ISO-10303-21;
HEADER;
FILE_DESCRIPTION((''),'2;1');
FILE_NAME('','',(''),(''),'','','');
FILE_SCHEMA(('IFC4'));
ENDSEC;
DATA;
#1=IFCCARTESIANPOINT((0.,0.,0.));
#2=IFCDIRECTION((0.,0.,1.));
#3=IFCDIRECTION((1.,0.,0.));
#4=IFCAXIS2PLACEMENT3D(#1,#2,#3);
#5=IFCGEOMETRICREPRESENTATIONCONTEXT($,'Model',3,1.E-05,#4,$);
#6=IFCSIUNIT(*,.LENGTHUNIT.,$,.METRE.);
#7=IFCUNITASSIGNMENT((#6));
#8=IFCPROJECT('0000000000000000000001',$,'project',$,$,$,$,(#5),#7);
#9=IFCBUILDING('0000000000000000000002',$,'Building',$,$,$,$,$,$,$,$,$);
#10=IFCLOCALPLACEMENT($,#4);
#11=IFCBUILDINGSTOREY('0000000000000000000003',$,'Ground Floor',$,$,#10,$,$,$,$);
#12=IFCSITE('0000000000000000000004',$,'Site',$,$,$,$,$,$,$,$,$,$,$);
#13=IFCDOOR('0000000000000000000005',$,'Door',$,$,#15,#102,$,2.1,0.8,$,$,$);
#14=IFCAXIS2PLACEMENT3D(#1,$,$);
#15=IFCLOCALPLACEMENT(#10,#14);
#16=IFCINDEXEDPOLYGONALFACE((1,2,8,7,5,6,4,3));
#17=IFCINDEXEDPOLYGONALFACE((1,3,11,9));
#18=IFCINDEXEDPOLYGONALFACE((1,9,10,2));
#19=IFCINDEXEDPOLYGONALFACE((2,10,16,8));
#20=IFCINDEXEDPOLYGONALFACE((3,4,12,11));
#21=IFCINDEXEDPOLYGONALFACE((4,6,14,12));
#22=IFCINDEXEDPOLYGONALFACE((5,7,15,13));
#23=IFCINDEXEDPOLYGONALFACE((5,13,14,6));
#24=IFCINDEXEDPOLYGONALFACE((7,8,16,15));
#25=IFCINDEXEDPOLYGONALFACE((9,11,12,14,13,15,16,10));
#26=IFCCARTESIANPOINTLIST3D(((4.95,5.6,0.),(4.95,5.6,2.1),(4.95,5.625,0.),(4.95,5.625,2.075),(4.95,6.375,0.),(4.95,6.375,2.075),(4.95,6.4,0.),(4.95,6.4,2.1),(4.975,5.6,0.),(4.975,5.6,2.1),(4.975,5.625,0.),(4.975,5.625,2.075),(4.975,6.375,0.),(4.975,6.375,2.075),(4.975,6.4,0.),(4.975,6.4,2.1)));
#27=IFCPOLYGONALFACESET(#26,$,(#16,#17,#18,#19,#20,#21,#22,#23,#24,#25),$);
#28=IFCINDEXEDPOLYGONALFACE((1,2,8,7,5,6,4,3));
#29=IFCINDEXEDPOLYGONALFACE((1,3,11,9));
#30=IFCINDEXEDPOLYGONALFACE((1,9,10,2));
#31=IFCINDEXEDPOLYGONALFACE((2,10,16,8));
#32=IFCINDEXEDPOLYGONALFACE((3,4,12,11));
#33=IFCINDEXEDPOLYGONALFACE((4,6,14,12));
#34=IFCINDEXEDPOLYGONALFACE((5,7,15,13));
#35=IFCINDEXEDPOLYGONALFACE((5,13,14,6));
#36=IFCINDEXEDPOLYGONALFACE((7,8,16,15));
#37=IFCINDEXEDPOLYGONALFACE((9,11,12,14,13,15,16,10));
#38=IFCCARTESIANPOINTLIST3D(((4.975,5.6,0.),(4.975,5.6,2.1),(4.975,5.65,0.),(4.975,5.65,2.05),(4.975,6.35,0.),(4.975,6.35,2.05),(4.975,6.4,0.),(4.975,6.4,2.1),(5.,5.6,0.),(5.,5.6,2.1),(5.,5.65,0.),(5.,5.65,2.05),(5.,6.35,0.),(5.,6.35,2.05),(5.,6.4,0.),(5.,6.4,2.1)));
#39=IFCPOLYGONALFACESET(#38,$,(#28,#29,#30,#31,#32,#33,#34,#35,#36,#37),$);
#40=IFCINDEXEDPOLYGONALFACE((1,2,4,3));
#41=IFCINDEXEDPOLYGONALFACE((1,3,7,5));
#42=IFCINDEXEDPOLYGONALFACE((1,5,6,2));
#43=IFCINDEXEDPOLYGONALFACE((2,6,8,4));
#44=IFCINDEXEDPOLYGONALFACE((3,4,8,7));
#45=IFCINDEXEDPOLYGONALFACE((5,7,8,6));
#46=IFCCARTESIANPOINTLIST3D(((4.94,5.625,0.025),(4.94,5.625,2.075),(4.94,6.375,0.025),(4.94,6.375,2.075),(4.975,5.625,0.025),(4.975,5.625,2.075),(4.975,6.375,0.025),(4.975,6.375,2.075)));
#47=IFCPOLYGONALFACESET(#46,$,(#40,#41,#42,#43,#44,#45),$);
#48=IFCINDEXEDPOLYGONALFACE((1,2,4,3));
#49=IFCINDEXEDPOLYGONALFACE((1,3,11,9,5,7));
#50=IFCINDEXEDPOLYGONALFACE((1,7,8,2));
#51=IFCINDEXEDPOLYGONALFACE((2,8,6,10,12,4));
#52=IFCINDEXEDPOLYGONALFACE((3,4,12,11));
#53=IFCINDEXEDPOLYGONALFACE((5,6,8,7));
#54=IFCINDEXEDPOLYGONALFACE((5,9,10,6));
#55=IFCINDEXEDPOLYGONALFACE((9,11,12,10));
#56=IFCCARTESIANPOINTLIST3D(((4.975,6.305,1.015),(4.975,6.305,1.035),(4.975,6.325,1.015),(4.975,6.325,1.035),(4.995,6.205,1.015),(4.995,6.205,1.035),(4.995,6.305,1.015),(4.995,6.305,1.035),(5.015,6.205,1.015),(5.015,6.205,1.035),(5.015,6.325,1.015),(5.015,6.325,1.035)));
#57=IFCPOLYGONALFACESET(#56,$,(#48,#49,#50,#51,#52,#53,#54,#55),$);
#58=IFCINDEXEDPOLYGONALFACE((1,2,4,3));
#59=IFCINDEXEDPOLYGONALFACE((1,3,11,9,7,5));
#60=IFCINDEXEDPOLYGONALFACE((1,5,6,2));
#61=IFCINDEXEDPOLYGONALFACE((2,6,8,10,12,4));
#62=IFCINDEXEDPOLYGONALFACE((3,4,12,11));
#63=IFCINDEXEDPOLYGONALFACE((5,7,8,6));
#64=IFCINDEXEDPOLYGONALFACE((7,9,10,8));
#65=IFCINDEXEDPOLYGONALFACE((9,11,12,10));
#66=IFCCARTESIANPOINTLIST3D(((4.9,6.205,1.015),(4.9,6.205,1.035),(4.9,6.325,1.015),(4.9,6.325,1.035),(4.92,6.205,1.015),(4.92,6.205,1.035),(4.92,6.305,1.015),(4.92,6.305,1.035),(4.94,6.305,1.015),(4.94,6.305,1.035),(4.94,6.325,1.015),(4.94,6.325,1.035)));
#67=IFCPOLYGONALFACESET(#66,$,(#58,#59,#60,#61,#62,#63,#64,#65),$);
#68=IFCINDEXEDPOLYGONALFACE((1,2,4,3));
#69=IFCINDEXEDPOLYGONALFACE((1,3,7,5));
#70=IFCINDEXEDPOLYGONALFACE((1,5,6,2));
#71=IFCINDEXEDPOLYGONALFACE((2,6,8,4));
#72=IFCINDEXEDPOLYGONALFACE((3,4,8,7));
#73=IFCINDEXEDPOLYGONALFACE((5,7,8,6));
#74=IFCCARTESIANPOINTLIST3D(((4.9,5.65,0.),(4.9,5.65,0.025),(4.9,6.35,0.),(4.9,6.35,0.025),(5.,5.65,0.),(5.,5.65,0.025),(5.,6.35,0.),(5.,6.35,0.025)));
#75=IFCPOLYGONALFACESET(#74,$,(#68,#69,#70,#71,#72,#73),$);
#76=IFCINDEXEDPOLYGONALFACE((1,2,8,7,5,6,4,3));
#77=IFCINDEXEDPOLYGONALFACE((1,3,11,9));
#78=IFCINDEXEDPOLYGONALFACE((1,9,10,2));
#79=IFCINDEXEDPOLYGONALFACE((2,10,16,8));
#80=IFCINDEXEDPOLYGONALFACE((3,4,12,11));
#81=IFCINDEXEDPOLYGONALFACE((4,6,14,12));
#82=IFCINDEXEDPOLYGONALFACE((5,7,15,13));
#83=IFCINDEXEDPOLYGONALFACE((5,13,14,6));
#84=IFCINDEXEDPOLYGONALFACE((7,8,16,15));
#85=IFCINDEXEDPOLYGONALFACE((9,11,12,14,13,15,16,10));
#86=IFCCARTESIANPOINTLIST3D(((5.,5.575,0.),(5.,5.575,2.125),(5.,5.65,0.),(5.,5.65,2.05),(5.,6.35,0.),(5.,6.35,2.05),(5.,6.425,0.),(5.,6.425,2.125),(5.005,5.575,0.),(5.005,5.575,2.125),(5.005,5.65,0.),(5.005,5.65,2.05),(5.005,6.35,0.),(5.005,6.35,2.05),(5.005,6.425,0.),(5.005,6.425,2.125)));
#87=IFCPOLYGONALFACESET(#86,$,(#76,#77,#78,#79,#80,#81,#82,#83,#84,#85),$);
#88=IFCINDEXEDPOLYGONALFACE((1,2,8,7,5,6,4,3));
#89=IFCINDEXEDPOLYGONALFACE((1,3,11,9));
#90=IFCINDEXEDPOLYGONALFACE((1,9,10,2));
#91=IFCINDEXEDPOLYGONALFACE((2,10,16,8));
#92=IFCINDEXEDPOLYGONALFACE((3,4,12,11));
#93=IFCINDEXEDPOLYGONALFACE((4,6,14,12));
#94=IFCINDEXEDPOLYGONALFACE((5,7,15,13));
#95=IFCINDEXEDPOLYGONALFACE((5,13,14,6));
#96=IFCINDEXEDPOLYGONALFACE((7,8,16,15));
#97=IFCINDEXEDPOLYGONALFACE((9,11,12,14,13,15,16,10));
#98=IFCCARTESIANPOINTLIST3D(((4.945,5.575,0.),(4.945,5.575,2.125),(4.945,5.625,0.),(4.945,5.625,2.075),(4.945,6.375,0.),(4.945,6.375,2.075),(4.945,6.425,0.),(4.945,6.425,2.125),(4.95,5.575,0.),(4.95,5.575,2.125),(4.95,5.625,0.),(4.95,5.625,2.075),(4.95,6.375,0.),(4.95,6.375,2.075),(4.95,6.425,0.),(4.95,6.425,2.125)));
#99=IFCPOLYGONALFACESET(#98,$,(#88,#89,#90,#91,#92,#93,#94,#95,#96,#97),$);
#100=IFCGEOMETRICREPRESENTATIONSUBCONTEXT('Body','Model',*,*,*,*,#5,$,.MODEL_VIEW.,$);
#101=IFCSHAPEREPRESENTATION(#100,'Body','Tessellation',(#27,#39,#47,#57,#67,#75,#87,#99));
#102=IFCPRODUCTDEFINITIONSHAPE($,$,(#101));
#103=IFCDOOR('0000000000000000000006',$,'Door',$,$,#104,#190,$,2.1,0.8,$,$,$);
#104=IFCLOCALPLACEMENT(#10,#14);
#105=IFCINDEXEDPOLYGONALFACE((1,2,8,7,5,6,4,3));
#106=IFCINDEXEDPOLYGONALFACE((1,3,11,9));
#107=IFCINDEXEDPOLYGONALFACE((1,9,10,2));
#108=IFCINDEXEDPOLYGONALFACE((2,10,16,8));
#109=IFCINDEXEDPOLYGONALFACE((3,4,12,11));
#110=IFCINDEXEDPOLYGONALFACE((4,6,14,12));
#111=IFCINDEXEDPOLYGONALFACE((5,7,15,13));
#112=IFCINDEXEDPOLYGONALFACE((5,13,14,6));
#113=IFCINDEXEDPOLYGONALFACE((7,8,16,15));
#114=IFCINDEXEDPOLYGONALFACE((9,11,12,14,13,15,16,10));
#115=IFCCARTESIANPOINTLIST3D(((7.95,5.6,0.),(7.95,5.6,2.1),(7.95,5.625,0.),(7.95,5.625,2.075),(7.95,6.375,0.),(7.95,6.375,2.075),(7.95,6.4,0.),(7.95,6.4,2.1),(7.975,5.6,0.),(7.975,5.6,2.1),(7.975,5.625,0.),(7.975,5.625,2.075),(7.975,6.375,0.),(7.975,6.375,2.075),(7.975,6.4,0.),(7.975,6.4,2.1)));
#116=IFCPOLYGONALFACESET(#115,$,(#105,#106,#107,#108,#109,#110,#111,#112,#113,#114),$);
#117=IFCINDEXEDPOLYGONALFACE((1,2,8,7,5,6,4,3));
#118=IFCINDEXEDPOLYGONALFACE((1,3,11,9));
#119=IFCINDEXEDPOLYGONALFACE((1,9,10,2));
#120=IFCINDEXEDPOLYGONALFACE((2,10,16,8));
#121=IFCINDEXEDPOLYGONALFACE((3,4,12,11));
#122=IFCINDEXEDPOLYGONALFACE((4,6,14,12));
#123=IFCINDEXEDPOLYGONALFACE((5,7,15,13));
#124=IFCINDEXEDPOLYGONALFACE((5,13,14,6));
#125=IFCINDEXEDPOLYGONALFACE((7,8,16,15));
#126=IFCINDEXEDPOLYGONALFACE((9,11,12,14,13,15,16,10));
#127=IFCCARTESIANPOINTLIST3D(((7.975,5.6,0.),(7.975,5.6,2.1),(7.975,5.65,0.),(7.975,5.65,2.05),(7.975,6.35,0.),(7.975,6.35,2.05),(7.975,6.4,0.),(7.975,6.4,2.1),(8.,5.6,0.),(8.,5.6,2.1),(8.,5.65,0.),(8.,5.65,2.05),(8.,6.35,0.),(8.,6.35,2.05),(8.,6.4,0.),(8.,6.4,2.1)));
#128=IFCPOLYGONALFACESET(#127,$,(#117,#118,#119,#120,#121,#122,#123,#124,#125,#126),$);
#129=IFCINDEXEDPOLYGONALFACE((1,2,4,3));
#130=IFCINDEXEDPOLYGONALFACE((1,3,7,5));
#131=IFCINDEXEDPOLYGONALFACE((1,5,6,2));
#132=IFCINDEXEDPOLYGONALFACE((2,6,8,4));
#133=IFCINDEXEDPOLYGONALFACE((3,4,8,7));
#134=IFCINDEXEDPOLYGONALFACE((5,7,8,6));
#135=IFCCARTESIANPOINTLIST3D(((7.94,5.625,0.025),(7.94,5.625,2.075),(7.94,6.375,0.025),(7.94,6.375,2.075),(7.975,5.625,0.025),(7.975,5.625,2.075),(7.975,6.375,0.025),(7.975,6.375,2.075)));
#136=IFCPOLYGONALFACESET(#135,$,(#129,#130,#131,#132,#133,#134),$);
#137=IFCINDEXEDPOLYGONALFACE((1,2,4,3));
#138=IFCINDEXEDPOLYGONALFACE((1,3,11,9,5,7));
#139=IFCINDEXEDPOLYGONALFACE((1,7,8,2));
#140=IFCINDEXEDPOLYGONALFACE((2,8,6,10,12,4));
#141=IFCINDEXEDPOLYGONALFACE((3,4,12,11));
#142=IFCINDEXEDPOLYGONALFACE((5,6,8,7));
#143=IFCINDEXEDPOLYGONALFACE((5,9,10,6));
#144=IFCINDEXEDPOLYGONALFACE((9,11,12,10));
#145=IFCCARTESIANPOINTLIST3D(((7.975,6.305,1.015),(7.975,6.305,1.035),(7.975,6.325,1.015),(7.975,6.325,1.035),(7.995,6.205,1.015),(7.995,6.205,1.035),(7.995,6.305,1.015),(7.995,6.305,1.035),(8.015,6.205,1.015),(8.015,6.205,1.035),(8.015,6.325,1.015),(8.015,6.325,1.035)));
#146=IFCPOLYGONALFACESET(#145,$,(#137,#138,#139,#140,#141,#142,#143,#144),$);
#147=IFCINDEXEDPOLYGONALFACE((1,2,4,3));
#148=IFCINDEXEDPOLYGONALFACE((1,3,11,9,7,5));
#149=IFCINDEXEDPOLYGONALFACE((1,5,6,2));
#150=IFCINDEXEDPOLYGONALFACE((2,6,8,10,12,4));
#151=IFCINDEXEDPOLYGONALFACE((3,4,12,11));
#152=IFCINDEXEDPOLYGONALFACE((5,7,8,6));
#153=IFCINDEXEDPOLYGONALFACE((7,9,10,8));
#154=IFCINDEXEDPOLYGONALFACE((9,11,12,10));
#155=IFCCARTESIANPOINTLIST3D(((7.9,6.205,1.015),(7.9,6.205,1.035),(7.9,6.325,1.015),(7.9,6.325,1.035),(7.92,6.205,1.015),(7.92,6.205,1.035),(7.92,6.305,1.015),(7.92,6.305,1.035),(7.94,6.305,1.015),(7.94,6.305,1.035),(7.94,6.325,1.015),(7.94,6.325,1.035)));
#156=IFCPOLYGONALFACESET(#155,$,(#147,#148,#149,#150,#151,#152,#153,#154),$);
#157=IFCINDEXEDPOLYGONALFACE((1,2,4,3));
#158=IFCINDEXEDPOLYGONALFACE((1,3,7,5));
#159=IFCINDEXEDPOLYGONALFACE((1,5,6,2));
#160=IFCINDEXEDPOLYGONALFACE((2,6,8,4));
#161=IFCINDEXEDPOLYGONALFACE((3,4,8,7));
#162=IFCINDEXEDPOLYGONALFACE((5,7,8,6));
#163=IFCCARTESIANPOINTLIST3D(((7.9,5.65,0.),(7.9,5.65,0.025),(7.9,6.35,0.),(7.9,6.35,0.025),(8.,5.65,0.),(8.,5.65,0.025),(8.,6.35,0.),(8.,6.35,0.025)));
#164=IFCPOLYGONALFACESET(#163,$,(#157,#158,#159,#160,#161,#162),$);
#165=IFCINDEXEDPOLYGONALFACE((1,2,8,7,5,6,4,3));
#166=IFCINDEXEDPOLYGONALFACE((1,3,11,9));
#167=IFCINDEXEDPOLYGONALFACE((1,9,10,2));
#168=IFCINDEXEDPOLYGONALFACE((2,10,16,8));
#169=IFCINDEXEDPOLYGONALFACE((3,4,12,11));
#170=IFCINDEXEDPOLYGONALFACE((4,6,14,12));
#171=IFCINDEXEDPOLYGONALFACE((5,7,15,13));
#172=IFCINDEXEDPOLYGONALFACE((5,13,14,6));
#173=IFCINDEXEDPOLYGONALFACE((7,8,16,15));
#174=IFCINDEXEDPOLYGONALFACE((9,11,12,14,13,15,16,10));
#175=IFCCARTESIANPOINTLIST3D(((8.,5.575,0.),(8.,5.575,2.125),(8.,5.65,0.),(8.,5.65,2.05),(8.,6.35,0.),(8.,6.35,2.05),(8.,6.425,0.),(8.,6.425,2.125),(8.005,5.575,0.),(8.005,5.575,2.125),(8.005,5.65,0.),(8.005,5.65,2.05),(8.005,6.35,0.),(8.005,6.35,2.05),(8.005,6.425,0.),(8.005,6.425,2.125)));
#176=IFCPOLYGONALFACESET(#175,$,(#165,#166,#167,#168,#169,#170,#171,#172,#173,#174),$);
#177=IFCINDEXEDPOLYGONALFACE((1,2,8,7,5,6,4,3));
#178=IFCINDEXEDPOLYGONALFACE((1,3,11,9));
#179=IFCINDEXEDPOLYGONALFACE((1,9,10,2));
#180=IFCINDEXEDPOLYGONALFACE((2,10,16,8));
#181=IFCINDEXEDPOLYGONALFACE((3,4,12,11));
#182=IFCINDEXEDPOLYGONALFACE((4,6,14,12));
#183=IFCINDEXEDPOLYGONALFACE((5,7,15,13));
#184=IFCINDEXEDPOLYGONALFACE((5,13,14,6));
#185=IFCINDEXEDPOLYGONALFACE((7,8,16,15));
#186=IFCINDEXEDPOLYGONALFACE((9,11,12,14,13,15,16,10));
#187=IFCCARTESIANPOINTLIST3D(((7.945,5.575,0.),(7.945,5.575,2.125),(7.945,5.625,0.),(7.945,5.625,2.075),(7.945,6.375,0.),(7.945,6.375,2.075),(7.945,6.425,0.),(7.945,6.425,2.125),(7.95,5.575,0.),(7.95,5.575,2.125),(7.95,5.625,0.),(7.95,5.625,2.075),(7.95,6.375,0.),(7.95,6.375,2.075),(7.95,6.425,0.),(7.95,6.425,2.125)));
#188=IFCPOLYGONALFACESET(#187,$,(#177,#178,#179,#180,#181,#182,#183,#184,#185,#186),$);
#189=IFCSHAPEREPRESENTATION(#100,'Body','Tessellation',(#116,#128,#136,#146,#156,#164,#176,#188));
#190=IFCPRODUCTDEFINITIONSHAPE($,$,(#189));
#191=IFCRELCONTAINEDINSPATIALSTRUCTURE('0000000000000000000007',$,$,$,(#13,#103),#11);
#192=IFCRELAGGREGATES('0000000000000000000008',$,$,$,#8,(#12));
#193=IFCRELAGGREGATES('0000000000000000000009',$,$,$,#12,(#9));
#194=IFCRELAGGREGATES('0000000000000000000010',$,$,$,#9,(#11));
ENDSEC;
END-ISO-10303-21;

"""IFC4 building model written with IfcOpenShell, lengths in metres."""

from ifc_helpers import new_model, si_unit, frame, origin_with_axes, place, context, subcontext, project, spatial, line, indexed_curve, outline, extrude, element, save


model = new_model("IFC4")

# Units and contexts
model_context = context("Model", 3, precision=1e-05, world=origin_with_axes())
body_context = subcontext(model_context, "Body", "Model", "MODEL_VIEW")
ifc_project = project(units=[si_unit("LENGTHUNIT", "METRE")], contexts=[model_context])

# Site, building, storey
site = spatial("IfcSite", under=ifc_project, Name="Site")
building = spatial("IfcBuilding", under=site, Name="Building")
storey_placement = place(None, origin_with_axes())
storey = spatial("IfcBuildingStorey", under=building, at=storey_placement, Name="Ground Floor")

# Doors
door_1_placement = place(storey_placement, frame((5.0, 5.6, 0.0), z_axis=(0.0, 0.0, 1.0), x_axis=(0.0, 1.0, 0.0)))
element("IfcDoor", 1, at=door_1_placement, inside=storey, Name="Door", OverallHeight=2.1, OverallWidth=0.8, context=body_context, shape_type="SweptSolid", body=[
    extrude(outline(indexed_curve([(0.0, 0.0), (0.0, 2.1), (0.8, 2.1), (0.8, 0.0), (0.775, 0.0), (0.775, 2.075), (0.025, 2.075), (0.025, 0.0)], segments=[line(1, 2, 3, 4, 5, 6, 7, 8, 1)])), frame((0.0, 0.025, 0.0), z_axis=(0.0, -1.0, 0.0), x_axis=(1.0, 0.0, 0.0)), (0.0, 0.0, -1.0), 0.025),
    extrude(outline(indexed_curve([(0.0, 0.0), (0.0, 2.1), (0.8, 2.1), (0.8, 0.0), (0.75, 0.0), (0.75, 2.05), (0.05, 2.05), (0.05, 0.0)], segments=[line(1, 2, 3, 4, 5, 6, 7, 8, 1)])), frame((0.0, 0.0, 0.0), z_axis=(0.0, -1.0, 0.0), x_axis=(1.0, 0.0, 0.0)), (0.0, 0.0, -1.0), 0.025),
    extrude(outline(indexed_curve([(0.0, 0.0), (0.75, 0.0), (0.75, 0.035), (0.0, 0.035)], segments=[line(1, 2, 3, 4, 1)])), frame((0.025, 0.025, 0.025), z_axis=(0.0, 0.0, 1.0), x_axis=(1.0, 0.0, 0.0)), (0.0, 0.0, 1.0), 2.05),
    extrude(outline(indexed_curve([(0.0, 0.0), (0.0, -0.04), (-0.12, -0.04), (-0.12, -0.02), (-0.02, -0.02), (-0.02, 0.0)], segments=[line(1, 2, 3, 4, 5, 6, 1)])), frame((0.725, 0.025, 1.015), z_axis=(0.0, 0.0, 1.0), x_axis=(1.0, 0.0, 0.0)), (0.0, 0.0, 1.0), 0.02),
    extrude(outline(indexed_curve([(0.0, 0.0), (0.0, 0.04), (-0.12, 0.04), (-0.12, 0.02), (-0.02, 0.02), (-0.02, 0.0)], segments=[line(1, 2, 3, 4, 5, 6, 1)])), frame((0.725, 0.06, 1.015), z_axis=(0.0, 0.0, 1.0), x_axis=(1.0, 0.0, 0.0)), (0.0, 0.0, 1.0), 0.02),
    extrude(outline(indexed_curve([(0.0, 0.0), (0.7, 0.0), (0.7, 0.1), (0.0, 0.1)], segments=[line(1, 2, 3, 4, 1)])), frame((0.05, 0.0, 0.0), z_axis=(0.0, 0.0, 1.0), x_axis=(1.0, 0.0, 0.0)), (0.0, 0.0, 1.0), 0.025),
    extrude(outline(indexed_curve([(0.0, 0.0), (0.0, 2.125), (0.85, 2.125), (0.85, 0.0), (0.775, 0.0), (0.775, 2.05), (0.075, 2.05), (0.075, 0.0)], segments=[line(1, 2, 3, 4, 5, 6, 7, 8, 1)])), frame((-0.025, -0.005, 0.0), z_axis=(0.0, -1.0, 0.0), x_axis=(1.0, 0.0, 0.0)), (0.0, 0.0, -1.0), 0.005),
    extrude(outline(indexed_curve([(0.0, 0.0), (0.0, 2.125), (0.85, 2.125), (0.85, 0.0), (0.8, 0.0), (0.8, 2.075), (0.05, 2.075), (0.05, 0.0)], segments=[line(1, 2, 3, 4, 5, 6, 7, 8, 1)])), frame((-0.025, 0.05, 0.0), z_axis=(0.0, -1.0, 0.0), x_axis=(1.0, 0.0, 0.0)), (0.0, 0.0, -1.0), 0.005),
])
door_2_placement = place(storey_placement, frame((8.0, 5.6, 0.0), z_axis=(0.0, 0.0, 1.0), x_axis=(0.0, 1.0, 0.0)))
element("IfcDoor", 2, at=door_2_placement, inside=storey, Name="Door", OverallHeight=2.1, OverallWidth=0.8, context=body_context, shape_type="SweptSolid", body=[
    extrude(outline(indexed_curve([(0.0, 0.0), (0.0, 2.1), (0.8, 2.1), (0.8, 0.0), (0.775, 0.0), (0.775, 2.075), (0.025, 2.075), (0.025, 0.0)], segments=[line(1, 2, 3, 4, 5, 6, 7, 8, 1)])), frame((0.0, 0.025, 0.0), z_axis=(0.0, -1.0, 0.0), x_axis=(1.0, 0.0, 0.0)), (0.0, 0.0, -1.0), 0.025),
    extrude(outline(indexed_curve([(0.0, 0.0), (0.0, 2.1), (0.8, 2.1), (0.8, 0.0), (0.75, 0.0), (0.75, 2.05), (0.05, 2.05), (0.05, 0.0)], segments=[line(1, 2, 3, 4, 5, 6, 7, 8, 1)])), frame((0.0, 0.0, 0.0), z_axis=(0.0, -1.0, 0.0), x_axis=(1.0, 0.0, 0.0)), (0.0, 0.0, -1.0), 0.025),
    extrude(outline(indexed_curve([(0.0, 0.0), (0.75, 0.0), (0.75, 0.035), (0.0, 0.035)], segments=[line(1, 2, 3, 4, 1)])), frame((0.025, 0.025, 0.025), z_axis=(0.0, 0.0, 1.0), x_axis=(1.0, 0.0, 0.0)), (0.0, 0.0, 1.0), 2.05),
    extrude(outline(indexed_curve([(0.0, 0.0), (0.0, -0.04), (-0.12, -0.04), (-0.12, -0.02), (-0.02, -0.02), (-0.02, 0.0)], segments=[line(1, 2, 3, 4, 5, 6, 1)])), frame((0.725, 0.025, 1.015), z_axis=(0.0, 0.0, 1.0), x_axis=(1.0, 0.0, 0.0)), (0.0, 0.0, 1.0), 0.02),
    extrude(outline(indexed_curve([(0.0, 0.0), (0.0, 0.04), (-0.12, 0.04), (-0.12, 0.02), (-0.02, 0.02), (-0.02, 0.0)], segments=[line(1, 2, 3, 4, 5, 6, 1)])), frame((0.725, 0.06, 1.015), z_axis=(0.0, 0.0, 1.0), x_axis=(1.0, 0.0, 0.0)), (0.0, 0.0, 1.0), 0.02),
    extrude(outline(indexed_curve([(0.0, 0.0), (0.7, 0.0), (0.7, 0.1), (0.0, 0.1)], segments=[line(1, 2, 3, 4, 1)])), frame((0.05, 0.0, 0.0), z_axis=(0.0, 0.0, 1.0), x_axis=(1.0, 0.0, 0.0)), (0.0, 0.0, 1.0), 0.025),
    extrude(outline(indexed_curve([(0.0, 0.0), (0.0, 2.125), (0.85, 2.125), (0.85, 0.0), (0.775, 0.0), (0.775, 2.05), (0.075, 2.05), (0.075, 0.0)], segments=[line(1, 2, 3, 4, 5, 6, 7, 8, 1)])), frame((-0.025, -0.005, 0.0), z_axis=(0.0, -1.0, 0.0), x_axis=(1.0, 0.0, 0.0)), (0.0, 0.0, -1.0), 0.005),
    extrude(outline(indexed_curve([(0.0, 0.0), (0.0, 2.125), (0.85, 2.125), (0.85, 0.0), (0.8, 0.0), (0.8, 2.075), (0.05, 2.075), (0.05, 0.0)], segments=[line(1, 2, 3, 4, 5, 6, 7, 8, 1)])), frame((-0.025, 0.05, 0.0), z_axis=(0.0, -1.0, 0.0), x_axis=(1.0, 0.0, 0.0)), (0.0, 0.0, -1.0), 0.005),
])

save(model, "model.ifc")
